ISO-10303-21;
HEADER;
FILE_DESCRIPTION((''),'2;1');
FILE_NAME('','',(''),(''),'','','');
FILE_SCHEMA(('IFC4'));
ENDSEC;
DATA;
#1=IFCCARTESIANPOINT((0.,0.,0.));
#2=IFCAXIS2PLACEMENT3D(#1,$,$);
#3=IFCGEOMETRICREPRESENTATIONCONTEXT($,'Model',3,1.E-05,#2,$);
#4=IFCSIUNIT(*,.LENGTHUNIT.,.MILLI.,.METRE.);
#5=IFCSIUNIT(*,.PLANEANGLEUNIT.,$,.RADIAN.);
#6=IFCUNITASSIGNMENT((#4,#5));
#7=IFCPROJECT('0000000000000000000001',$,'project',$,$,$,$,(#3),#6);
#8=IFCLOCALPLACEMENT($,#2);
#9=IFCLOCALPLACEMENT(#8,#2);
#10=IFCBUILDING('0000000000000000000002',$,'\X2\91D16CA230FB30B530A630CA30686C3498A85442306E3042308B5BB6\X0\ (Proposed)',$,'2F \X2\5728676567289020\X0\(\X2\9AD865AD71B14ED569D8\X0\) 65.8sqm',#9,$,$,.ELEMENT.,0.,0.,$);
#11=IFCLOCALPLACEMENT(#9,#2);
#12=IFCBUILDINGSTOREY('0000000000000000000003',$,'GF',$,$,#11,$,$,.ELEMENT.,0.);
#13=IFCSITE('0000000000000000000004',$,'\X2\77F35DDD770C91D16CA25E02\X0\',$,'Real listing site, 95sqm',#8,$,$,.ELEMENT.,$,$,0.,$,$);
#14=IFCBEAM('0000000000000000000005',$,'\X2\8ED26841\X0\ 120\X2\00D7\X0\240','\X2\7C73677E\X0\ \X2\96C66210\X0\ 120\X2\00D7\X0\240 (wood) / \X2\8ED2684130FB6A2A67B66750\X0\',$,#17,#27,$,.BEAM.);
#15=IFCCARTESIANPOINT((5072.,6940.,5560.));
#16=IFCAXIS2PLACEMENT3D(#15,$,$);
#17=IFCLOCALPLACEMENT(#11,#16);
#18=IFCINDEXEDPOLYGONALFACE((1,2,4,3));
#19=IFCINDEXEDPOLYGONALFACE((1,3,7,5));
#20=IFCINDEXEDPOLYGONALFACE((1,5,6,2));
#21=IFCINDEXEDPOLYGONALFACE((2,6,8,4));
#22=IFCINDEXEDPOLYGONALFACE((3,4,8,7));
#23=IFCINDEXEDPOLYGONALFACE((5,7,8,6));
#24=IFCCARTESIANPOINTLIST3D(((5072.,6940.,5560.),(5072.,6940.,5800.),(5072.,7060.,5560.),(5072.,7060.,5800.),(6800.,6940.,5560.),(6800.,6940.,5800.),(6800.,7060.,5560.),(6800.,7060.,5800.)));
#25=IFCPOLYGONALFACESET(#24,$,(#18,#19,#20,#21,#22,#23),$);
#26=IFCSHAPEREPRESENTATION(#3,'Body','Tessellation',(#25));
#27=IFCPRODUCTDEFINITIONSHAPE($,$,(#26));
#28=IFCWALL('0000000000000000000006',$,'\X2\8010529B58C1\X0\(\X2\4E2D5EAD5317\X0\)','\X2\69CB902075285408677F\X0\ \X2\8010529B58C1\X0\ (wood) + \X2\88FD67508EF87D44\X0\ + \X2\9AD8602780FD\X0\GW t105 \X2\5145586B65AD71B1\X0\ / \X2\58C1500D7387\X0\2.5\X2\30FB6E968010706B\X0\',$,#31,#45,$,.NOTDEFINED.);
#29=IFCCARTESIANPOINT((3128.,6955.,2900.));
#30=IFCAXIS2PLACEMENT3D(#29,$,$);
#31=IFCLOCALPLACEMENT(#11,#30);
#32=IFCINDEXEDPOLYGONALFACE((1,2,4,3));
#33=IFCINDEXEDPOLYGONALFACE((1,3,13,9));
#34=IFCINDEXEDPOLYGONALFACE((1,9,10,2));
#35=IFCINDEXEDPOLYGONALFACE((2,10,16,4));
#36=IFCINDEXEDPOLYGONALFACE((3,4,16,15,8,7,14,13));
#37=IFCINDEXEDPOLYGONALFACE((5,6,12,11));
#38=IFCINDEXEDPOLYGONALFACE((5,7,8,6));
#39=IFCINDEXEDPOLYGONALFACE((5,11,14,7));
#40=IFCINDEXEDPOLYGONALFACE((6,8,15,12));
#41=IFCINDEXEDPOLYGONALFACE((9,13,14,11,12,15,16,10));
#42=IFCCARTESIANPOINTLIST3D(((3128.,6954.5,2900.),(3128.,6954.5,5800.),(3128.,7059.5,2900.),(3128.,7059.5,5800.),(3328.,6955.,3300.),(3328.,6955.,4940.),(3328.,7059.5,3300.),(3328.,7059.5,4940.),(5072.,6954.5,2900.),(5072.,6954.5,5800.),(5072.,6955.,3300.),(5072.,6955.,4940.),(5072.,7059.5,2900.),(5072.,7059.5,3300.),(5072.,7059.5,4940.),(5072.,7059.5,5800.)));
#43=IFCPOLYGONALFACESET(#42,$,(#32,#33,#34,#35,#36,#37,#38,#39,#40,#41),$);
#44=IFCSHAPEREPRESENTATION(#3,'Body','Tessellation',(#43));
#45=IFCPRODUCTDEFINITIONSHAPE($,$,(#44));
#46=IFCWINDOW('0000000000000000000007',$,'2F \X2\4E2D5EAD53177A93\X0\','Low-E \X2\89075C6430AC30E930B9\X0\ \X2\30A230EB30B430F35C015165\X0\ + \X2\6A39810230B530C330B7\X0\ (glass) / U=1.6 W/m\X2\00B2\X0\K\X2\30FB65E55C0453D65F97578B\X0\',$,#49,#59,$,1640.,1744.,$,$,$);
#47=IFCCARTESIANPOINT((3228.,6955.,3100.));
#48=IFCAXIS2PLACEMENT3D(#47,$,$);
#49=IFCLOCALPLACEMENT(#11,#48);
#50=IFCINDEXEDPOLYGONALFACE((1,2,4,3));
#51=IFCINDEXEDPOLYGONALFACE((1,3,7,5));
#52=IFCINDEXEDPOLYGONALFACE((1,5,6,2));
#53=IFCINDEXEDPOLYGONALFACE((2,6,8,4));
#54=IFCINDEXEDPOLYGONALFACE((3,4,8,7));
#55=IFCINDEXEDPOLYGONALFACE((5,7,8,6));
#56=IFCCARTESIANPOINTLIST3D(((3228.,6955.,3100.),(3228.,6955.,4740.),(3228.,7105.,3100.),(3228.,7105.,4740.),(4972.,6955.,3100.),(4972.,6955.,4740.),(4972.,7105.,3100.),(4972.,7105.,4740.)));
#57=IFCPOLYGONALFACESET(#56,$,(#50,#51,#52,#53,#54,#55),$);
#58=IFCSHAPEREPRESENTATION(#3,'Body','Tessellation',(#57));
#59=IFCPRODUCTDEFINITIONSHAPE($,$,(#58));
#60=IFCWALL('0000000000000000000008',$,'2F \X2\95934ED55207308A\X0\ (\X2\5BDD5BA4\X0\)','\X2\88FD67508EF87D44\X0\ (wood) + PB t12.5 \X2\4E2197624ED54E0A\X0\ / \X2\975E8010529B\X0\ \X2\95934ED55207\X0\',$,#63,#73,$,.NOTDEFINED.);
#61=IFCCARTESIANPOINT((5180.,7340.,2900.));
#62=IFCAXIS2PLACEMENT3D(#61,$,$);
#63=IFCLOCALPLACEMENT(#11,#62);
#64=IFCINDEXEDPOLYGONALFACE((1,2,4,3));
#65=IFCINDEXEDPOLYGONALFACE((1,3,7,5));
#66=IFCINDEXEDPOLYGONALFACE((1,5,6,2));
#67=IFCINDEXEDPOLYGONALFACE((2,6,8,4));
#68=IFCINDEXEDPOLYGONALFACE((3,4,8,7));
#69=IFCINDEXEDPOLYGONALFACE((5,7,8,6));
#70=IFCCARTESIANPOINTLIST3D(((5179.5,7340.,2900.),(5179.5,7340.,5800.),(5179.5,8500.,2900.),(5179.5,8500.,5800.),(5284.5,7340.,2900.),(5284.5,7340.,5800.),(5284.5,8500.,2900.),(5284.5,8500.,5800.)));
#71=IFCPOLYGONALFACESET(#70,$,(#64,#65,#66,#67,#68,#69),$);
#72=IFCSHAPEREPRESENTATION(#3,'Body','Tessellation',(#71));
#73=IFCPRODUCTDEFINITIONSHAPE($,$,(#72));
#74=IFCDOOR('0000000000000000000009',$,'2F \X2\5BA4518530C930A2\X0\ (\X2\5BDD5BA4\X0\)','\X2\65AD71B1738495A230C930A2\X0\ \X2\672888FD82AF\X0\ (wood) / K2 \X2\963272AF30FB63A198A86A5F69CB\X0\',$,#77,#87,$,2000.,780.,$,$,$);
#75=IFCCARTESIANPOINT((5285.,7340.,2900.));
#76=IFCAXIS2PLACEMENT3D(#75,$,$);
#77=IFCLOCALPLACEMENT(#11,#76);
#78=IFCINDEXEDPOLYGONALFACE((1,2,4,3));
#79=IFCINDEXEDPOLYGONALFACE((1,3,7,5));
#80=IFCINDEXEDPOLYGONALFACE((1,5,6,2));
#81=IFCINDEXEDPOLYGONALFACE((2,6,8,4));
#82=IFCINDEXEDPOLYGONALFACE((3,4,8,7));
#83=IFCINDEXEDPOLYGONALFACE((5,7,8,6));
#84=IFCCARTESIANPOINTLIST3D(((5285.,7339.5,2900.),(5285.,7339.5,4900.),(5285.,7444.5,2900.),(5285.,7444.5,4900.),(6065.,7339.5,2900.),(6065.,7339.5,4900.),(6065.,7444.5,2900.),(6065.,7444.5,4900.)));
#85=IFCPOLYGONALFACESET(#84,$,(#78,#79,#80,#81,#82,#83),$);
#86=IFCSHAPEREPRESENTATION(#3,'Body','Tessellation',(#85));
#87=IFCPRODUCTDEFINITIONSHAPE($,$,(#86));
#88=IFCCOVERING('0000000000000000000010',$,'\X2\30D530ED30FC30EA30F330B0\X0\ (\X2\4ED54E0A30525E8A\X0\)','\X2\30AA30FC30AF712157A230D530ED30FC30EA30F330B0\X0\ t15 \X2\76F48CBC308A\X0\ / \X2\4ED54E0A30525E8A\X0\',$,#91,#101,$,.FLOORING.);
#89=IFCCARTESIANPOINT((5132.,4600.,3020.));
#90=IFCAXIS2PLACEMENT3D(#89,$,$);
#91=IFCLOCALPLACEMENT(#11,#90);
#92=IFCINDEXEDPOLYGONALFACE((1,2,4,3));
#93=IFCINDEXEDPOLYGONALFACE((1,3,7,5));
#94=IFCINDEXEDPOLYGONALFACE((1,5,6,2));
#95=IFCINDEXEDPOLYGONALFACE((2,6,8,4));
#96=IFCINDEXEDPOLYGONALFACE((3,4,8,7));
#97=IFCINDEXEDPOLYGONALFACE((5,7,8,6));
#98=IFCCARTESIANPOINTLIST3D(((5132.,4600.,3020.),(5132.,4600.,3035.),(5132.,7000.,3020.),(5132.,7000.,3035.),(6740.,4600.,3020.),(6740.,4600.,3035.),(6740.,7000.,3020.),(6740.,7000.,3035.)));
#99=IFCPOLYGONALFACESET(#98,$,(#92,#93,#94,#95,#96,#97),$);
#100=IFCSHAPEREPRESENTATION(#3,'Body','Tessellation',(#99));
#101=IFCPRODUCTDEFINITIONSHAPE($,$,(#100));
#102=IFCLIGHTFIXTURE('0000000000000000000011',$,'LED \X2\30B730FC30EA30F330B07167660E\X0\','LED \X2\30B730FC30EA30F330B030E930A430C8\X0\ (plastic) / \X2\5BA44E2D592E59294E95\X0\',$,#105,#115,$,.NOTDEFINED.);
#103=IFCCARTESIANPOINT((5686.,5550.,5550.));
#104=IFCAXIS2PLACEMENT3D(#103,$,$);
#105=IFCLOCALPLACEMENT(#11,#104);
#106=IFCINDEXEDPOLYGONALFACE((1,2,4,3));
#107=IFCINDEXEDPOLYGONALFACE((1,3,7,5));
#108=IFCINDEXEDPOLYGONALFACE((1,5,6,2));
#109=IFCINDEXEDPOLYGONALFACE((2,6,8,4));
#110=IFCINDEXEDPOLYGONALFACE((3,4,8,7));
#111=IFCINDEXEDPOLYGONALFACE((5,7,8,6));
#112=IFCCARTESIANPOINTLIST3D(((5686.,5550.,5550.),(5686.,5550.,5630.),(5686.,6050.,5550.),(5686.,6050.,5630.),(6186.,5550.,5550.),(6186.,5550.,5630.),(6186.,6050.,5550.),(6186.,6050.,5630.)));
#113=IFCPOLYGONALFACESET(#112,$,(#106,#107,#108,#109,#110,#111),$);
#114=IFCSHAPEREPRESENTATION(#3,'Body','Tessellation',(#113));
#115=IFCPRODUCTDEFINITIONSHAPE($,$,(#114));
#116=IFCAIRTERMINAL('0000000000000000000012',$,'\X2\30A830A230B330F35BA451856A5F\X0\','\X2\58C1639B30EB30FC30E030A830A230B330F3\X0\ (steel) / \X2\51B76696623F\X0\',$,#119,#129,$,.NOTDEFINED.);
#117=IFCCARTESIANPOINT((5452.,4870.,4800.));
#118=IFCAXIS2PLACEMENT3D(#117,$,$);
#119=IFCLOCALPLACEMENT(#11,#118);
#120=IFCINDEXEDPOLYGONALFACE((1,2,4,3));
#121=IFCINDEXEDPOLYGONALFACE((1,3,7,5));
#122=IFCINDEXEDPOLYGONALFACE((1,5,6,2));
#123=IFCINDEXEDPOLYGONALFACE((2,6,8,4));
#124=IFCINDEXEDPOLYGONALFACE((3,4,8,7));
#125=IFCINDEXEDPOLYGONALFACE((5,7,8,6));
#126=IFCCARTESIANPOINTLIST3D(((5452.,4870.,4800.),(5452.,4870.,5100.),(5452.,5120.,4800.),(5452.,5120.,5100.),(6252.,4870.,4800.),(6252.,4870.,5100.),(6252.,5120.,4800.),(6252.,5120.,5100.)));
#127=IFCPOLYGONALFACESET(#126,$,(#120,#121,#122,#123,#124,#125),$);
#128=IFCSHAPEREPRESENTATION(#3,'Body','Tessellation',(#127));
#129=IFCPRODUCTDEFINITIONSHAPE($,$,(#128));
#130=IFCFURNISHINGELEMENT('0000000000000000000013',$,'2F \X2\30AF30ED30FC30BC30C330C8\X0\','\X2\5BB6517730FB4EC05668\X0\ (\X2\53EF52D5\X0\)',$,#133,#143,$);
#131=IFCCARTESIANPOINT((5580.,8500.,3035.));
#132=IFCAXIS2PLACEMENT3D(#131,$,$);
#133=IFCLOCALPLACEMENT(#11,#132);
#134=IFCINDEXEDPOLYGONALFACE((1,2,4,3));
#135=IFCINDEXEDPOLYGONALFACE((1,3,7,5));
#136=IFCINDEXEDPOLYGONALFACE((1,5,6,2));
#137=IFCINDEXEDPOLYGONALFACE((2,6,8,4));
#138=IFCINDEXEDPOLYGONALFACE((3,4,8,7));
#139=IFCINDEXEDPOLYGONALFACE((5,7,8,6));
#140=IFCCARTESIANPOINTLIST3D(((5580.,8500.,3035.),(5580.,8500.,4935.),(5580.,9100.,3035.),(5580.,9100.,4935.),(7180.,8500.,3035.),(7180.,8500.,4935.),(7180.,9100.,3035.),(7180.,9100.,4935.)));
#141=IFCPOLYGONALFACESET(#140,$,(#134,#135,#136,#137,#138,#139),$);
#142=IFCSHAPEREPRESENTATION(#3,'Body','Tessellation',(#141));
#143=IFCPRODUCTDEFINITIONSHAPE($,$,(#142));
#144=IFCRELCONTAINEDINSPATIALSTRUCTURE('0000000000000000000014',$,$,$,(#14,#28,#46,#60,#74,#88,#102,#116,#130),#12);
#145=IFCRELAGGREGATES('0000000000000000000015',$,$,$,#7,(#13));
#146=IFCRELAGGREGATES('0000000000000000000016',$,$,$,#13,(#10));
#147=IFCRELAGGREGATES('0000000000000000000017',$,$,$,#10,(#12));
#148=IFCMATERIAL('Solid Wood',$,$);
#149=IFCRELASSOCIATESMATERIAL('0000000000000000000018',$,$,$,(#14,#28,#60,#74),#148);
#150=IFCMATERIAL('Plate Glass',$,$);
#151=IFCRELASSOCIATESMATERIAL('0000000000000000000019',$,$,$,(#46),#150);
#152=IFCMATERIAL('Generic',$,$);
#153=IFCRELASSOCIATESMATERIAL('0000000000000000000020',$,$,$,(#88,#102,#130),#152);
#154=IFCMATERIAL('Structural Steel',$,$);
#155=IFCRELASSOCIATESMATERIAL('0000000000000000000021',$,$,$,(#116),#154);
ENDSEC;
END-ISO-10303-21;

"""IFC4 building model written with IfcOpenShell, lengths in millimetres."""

from ifc_helpers import new_model, si_unit, frame, frame_2d, origin, place, context, project, spatial, rectangle, extrude, material, element, fill, save


model = new_model("IFC4")

# Units and contexts
model_context = context("Model", 3, precision=1e-05, world=origin())
ifc_project = project(units=[si_unit("LENGTHUNIT", "METRE", prefix="MILLI"), si_unit("PLANEANGLEUNIT", "RADIAN")], contexts=[model_context])

# Site, building, storey
site_placement = place(None, origin())
site = spatial("IfcSite", under=ifc_project, at=site_placement, Name="石川県金沢市", ObjectType="Real listing site, 95sqm", CompositionType="ELEMENT", RefElevation=0.0)
building_placement = place(site_placement, origin())
building = spatial("IfcBuilding", under=site, at=building_placement, Name="金沢・サウナと水風呂のある家 (Proposed)", ObjectType="2F 在来木造(高断熱仕様) 65.8sqm", CompositionType="ELEMENT", ElevationOfRefHeight=0.0, ElevationOfTerrain=0.0)
storey_placement = place(building_placement, origin())
storey = spatial("IfcBuildingStorey", under=building, at=storey_placement, Name="GF", CompositionType="ELEMENT", Elevation=0.0)

# Shared definitions
ifc_material_1 = material(Name="Solid Wood")

# Beam
beam_1_placement = place(storey_placement, frame((5072.0, 6940.0, 5560.0)))
element("IfcBeam", 1, at=beam_1_placement, inside=storey, material=ifc_material_1, Name="軒桁 120×240", Description="米松 集成 120×240 (wood) / 軒桁・横架材", PredefinedType="BEAM", context=model_context, shape_type="SweptSolid", body=[
    extrude(rectangle(XDim=1728.0, YDim=120.0, at=frame_2d((864.0, 60.0))), frame((5072.0, 6940.0, 5560.0)), (0.0, 0.0, 1.0), 240.0),
])

# Wall, opening, window
wall_1_placement = place(storey_placement, frame((3128.0, 6955.0, 2900.0)))
wall_1 = element("IfcWall", 2, at=wall_1_placement, inside=storey, material=ifc_material_1, Name="耐力壁(中庭北)", Description="構造用合板 耐力壁 (wood) + 製材軸組 + 高性能GW t105 充填断熱 / 壁倍率2.5・準耐火", PredefinedType="NOTDEFINED", context=model_context, shape_type="SweptSolid", body=[
    extrude(rectangle(XDim=1944.0, YDim=105.0, at=frame_2d((972.0, 52.0))), frame((3128.0, 6955.0, 2900.0)), (0.0, 0.0, 1.0), 2900.0),
])
opening_placement = place(storey_placement, frame((3228.0, 6955.0, 3100.0)))
opening = element("IfcOpeningElement", 3, at=opening_placement, cuts=wall_1, PredefinedType="NOTDEFINED", context=model_context, shape_type="SweptSolid", body=[
    extrude(rectangle(XDim=1744.0, YDim=150.0, at=frame_2d((872.0, 75.0))), frame((3228.0, 6955.0, 3100.0)), (0.0, 0.0, 1.0), 1640.0),
])
ifc_material_2 = material(Name="Plate Glass")
window_placement = place(storey_placement, frame((3228.0, 6955.0, 3100.0)))
window = element("IfcWindow", 4, at=window_placement, inside=storey, material=ifc_material_2, Name="2F 中庭北窓", Description="Low-E 複層ガラス アルゴン封入 + 樹脂サッシ (glass) / U=1.6 W/m²K・日射取得型", OverallHeight=1640.0, OverallWidth=1744.0, context=model_context, shape_type="SweptSolid", body=[
    extrude(rectangle(XDim=1744.0, YDim=150.0, at=frame_2d((872.0, 75.0))), frame((3228.0, 6955.0, 3100.0)), (0.0, 0.0, 1.0), 1640.0),
])
fill(opening, window)

# Wall
wall_2_placement = place(storey_placement, frame((5180.0, 7340.0, 2900.0)))
element("IfcWall", 5, at=wall_2_placement, inside=storey, material=ifc_material_1, Name="2F 間仕切り (寝室)", Description="製材軸組 (wood) + PB t12.5 両面仕上 / 非耐力 間仕切", PredefinedType="NOTDEFINED", context=model_context, shape_type="SweptSolid", body=[
    extrude(rectangle(XDim=105.0, YDim=1160.0, at=frame_2d((52.0, 580.0))), frame((5180.0, 7340.0, 2900.0)), (0.0, 0.0, 1.0), 2900.0),
])

# Door
door_placement = place(storey_placement, frame((5285.0, 7340.0, 2900.0)))
element("IfcDoor", 6, at=door_placement, inside=storey, material=ifc_material_1, Name="2F 室内ドア (寝室)", Description="断熱玄関ドア 木製芯 (wood) / K2 防犯・採風機構", OverallHeight=2000.0, OverallWidth=780.0, context=model_context, shape_type="SweptSolid", body=[
    extrude(rectangle(XDim=780.0, YDim=105.0, at=frame_2d((390.0, 52.0))), frame((5285.0, 7340.0, 2900.0)), (0.0, 0.0, 1.0), 2000.0),
])

# Covering
ifc_material_3 = material(Name="Generic")
covering_placement = place(storey_placement, frame((5132.0, 4600.0, 3020.0)))
element("IfcCovering", 7, at=covering_placement, inside=storey, material=ifc_material_3, Name="フローリング (仕上げ床)", Description="オーク無垢フローリング t15 直貼り / 仕上げ床", PredefinedType="FLOORING", context=model_context, shape_type="SweptSolid", body=[
    extrude(rectangle(XDim=1608.0, YDim=2400.0, at=frame_2d((804.0, 1200.0))), frame((5132.0, 4600.0, 3020.0)), (0.0, 0.0, 1.0), 15.0),
])

# Light fixture
light_fixture_placement = place(storey_placement, frame((5686.0, 5550.0, 5550.0)))
element("IfcLightFixture", 8, at=light_fixture_placement, inside=storey, material=ifc_material_3, Name="LED シーリング照明", Description="LED シーリングライト (plastic) / 室中央天井", PredefinedType="NOTDEFINED", context=model_context, shape_type="SweptSolid", body=[
    extrude(rectangle(XDim=500.0, YDim=500.0, at=frame_2d((250.0, 250.0))), frame((5686.0, 5550.0, 5550.0)), (0.0, 0.0, 1.0), 80.0),
])

# Air terminal
ifc_material_4 = material(Name="Structural Steel")
air_terminal_placement = place(storey_placement, frame((5452.0, 4870.0, 4800.0)))
element("IfcAirTerminal", 9, at=air_terminal_placement, inside=storey, material=ifc_material_4, Name="エアコン室内機", Description="壁掛ルームエアコン (steel) / 冷暖房", PredefinedType="NOTDEFINED", context=model_context, shape_type="SweptSolid", body=[
    extrude(rectangle(XDim=800.0, YDim=250.0, at=frame_2d((400.0, 125.0))), frame((5452.0, 4870.0, 4800.0)), (0.0, 0.0, 1.0), 300.0),
])

# Furnishing element
furnishing_placement = place(storey_placement, frame((5580.0, 8500.0, 3035.0)))
element("IfcFurnishingElement", 10, at=furnishing_placement, inside=storey, material=ifc_material_3, Name="2F クローゼット", Description="家具・什器 (可動)", context=model_context, shape_type="SweptSolid", body=[
    extrude(rectangle(XDim=1600.0, YDim=600.0, at=frame_2d((800.0, 300.0))), frame((5580.0, 8500.0, 3035.0)), (0.0, 0.0, 1.0), 1900.0),
])

save(model, "model.ifc")
